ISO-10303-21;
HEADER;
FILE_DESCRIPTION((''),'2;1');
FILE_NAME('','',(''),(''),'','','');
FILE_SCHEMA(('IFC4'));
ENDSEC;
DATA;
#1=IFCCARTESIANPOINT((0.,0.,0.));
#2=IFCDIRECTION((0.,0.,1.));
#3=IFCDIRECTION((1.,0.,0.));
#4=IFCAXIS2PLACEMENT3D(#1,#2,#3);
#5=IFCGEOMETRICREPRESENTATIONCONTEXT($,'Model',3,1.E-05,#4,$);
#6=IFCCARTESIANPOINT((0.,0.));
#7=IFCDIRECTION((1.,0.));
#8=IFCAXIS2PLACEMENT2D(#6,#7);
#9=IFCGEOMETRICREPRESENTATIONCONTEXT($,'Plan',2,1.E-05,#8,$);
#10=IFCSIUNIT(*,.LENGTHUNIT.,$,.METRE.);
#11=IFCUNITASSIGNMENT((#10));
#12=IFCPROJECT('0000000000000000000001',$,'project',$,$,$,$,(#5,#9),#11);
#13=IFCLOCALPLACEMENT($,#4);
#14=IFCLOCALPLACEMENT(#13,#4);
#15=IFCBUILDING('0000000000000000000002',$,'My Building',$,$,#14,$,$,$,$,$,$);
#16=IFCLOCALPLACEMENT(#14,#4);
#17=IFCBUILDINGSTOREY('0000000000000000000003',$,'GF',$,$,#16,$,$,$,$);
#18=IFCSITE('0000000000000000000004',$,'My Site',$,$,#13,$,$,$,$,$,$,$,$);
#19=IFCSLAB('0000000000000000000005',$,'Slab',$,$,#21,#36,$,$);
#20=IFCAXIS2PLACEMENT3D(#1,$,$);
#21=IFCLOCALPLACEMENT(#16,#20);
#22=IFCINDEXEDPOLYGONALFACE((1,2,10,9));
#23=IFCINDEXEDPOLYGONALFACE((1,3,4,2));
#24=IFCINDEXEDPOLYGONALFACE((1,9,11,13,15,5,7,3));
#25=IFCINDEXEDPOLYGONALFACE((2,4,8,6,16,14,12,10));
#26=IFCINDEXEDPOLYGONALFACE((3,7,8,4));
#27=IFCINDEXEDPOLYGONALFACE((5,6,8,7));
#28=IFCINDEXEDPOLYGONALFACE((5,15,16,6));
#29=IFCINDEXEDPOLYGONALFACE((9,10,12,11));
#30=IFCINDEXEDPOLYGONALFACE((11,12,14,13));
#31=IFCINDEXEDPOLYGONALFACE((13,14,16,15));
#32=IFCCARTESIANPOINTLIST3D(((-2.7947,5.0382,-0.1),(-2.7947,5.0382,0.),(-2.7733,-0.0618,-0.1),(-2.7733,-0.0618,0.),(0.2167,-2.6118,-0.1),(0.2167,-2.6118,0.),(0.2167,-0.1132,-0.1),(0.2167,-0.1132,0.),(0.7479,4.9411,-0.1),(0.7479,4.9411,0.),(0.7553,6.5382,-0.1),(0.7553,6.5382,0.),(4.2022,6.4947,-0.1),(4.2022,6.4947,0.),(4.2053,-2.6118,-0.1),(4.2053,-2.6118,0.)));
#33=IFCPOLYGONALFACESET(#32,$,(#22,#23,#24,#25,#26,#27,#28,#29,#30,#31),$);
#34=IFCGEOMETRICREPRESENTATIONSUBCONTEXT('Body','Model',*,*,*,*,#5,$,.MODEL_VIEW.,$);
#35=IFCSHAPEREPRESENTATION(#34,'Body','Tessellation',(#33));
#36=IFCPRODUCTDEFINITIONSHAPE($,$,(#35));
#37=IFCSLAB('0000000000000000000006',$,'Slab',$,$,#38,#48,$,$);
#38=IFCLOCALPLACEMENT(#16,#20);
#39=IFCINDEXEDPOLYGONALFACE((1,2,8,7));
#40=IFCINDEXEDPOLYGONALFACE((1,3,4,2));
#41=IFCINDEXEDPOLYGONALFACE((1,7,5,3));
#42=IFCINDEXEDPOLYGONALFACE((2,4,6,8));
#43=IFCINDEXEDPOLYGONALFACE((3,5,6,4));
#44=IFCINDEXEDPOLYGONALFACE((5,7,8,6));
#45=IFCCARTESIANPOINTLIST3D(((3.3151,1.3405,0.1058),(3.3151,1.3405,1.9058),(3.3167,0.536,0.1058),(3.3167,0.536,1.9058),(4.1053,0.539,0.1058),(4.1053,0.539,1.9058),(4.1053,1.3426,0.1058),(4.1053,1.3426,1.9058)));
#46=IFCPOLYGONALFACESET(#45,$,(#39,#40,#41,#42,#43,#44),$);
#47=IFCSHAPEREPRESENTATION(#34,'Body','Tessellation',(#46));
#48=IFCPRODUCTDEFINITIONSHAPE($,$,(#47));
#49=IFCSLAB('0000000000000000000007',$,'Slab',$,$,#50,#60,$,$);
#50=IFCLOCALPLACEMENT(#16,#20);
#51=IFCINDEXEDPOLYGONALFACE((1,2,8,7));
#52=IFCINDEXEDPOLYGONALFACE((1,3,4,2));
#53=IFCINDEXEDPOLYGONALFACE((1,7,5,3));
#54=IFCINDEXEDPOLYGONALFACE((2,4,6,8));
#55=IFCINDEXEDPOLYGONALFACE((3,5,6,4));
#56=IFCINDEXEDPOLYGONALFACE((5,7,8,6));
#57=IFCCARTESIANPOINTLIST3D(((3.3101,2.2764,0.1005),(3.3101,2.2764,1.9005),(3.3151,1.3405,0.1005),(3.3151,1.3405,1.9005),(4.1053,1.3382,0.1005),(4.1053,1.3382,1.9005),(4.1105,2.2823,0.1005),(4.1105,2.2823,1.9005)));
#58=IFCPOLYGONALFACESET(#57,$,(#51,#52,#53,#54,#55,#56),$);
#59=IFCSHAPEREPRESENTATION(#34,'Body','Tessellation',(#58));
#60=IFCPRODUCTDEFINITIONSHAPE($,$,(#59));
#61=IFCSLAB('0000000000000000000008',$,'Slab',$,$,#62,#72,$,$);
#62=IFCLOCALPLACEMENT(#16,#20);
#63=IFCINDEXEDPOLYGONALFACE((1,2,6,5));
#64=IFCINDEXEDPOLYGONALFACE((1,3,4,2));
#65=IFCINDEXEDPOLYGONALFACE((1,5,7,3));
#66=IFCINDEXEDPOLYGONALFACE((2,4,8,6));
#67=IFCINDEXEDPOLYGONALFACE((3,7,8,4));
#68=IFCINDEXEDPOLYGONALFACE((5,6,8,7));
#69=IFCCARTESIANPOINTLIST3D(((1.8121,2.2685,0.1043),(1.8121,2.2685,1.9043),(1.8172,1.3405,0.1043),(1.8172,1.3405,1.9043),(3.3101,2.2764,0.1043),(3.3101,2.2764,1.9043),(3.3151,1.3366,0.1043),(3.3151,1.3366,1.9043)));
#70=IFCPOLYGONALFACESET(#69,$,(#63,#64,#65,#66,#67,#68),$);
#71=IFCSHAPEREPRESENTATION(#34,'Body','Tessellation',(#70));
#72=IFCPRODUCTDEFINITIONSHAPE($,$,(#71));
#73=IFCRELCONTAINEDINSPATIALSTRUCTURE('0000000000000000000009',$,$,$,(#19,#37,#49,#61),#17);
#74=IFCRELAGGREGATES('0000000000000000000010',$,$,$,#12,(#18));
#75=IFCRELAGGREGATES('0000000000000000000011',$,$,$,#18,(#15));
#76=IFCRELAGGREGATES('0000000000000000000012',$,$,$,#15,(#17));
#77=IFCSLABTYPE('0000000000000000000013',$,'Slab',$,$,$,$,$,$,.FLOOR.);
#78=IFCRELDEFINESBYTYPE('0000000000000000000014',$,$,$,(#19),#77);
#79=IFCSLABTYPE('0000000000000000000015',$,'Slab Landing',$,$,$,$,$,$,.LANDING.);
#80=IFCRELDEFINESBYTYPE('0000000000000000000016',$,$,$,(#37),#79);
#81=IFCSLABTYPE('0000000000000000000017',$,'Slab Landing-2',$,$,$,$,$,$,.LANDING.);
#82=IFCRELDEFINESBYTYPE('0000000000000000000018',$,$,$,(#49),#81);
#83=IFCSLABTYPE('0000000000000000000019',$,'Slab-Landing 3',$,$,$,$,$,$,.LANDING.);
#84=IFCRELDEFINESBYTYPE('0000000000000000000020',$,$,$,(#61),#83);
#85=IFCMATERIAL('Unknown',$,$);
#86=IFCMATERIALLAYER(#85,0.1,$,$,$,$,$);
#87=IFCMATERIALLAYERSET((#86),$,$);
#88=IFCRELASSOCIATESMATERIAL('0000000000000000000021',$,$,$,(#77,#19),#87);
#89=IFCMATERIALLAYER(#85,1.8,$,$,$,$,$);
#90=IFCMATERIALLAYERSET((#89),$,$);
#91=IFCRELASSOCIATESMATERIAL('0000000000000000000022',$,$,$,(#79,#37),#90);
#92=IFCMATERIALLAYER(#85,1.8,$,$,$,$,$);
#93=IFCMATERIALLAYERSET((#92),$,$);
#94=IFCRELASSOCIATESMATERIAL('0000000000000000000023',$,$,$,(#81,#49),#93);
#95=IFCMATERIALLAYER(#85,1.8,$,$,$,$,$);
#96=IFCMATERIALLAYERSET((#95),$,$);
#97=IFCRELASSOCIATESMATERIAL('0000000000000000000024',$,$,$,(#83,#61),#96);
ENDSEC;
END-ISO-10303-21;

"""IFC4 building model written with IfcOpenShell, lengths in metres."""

from ifc_helpers import new_model, si_unit, frame, origin_with_axes, origin_2d_with_axis, place, context, subcontext, project, spatial, indexed_curve, outline, extrude, material, layer, layer_set, layer_usage, type_object, element, save


model = new_model("IFC4")

# Units and contexts
model_context = context("Model", 3, precision=1e-05, world=origin_with_axes())
plan_context = context("Plan", 2, precision=1e-05, world=origin_2d_with_axis())
body_context_1 = subcontext(model_context, "Body", "Model", "MODEL_VIEW")
ifc_project = project(units=[si_unit("LENGTHUNIT", "METRE")], contexts=[model_context, plan_context])

# Site, building, storey
site_placement = place(None, origin_with_axes())
site = spatial("IfcSite", under=ifc_project, at=site_placement, Name="My Site")
building_placement = place(site_placement, origin_with_axes())
building = spatial("IfcBuilding", under=site, at=building_placement, Name="My Building")
storey_placement = place(building_placement, origin_with_axes())
storey = spatial("IfcBuildingStorey", under=building, at=storey_placement, Name="GF")

# Slabs
ifc_material_1 = material(Name="Unknown")
ifc_layer_1 = layer(ifc_material_1, 0.1)
ifc_layer_set_1 = layer_set([ifc_layer_1])
ifc_layer_usage_1 = layer_usage(ifc_layer_set_1, "AXIS3", "POSITIVE", -0.1)
slab_type_1 = type_object("IfcSlabType", Name="Slab", PredefinedType="FLOOR", material=ifc_layer_set_1)
slab_1_placement = place(storey_placement, frame((4.2022, 6.4947, 0.0), z_axis=(0.0, 0.0, 1.0), x_axis=(1.0, 0.0, 0.0)))
element("IfcSlab", 1, at=slab_1_placement, inside=storey, type_object=slab_type_1, material=ifc_layer_usage_1, Name="Slab", context=body_context_1, shape_type="SweptSolid", body=[
    extrude(outline(indexed_curve([(0.0, 0.0), (-3.4469, 0.0435), (-3.4543, -1.5535), (-6.9969, -1.4565), (-6.9755, -6.5565), (-3.9855, -6.6078), (-3.9855, -9.1065), (0.0031, -9.1065), (0.0, 0.0)])), frame((0.0, 0.0, -0.1), z_axis=(0.0, 0.0, 1.0), x_axis=(1.0, 0.0, 0.0)), (0.0, 0.0, 1.0), 0.1),
])
ifc_layer_2 = layer(ifc_material_1, 1.8)
ifc_layer_set_2 = layer_set([ifc_layer_2])
ifc_layer_usage_2 = layer_usage(ifc_layer_set_2, "AXIS3", "POSITIVE", -0.1)
slab_type_2 = type_object("IfcSlabType", Name="Slab Landing", PredefinedType="LANDING", material=ifc_layer_set_2)
slab_2_placement = place(storey_placement, frame((3.3167, 0.536, 0.2058), z_axis=(0.0, 0.0, 1.0), x_axis=(1.0, 0.0, 0.0)))
element("IfcSlab", 2, at=slab_2_placement, inside=storey, type_object=slab_type_2, material=ifc_layer_usage_2, Name="Slab", context=body_context_1, shape_type="SweptSolid", body=[
    extrude(outline(indexed_curve([(-0.0016, 0.8044), (0.7886, 0.8066), (0.7886, 0.003), (0.0, 0.0), (-0.0016, 0.8044)])), frame((0.0, 0.0, -0.1), z_axis=(0.0, 0.0, 1.0), x_axis=(1.0, 0.0, 0.0)), (0.0, 0.0, 1.0), 1.8),
])
ifc_layer_3 = layer(ifc_material_1, 1.8)
ifc_layer_set_3 = layer_set([ifc_layer_3])
ifc_layer_usage_3 = layer_usage(ifc_layer_set_3, "AXIS3", "POSITIVE", -1.8)
slab_type_3 = type_object("IfcSlabType", Name="Slab Landing-2", PredefinedType="LANDING", material=ifc_layer_set_3)
slab_3_placement = place(storey_placement, frame((3.3151, 1.3405, 1.9005), z_axis=(0.0, 0.0, 1.0), x_axis=(1.0, 0.0, 0.0)))
element("IfcSlab", 3, at=slab_3_placement, inside=storey, type_object=slab_type_3, material=ifc_layer_usage_3, Name="Slab", context=body_context_1, shape_type="SweptSolid", body=[
    extrude(outline(indexed_curve([(0.0, 0.0), (-0.005, 0.936), (0.7954, 0.9418), (0.7902, -0.0023), (0.0, 0.0)])), frame((0.0, 0.0, -1.8), z_axis=(0.0, 0.0, 1.0), x_axis=(1.0, 0.0, 0.0)), (0.0, 0.0, 1.0), 1.8),
])
ifc_layer_4 = layer(ifc_material_1, 1.8)
ifc_layer_set_4 = layer_set([ifc_layer_4])
ifc_layer_usage_4 = layer_usage(ifc_layer_set_4, "AXIS3", "POSITIVE", -1.8)
slab_type_4 = type_object("IfcSlabType", Name="Slab-Landing 3", PredefinedType="LANDING", material=ifc_layer_set_4)
slab_4_placement = place(storey_placement, frame((1.8172, 1.3405, 1.9043), z_axis=(0.0, 0.0, 1.0), x_axis=(1.0, 0.0, 0.0)))
element("IfcSlab", 4, at=slab_4_placement, inside=storey, type_object=slab_type_4, material=ifc_layer_usage_4, Name="Slab", context=body_context_1, shape_type="SweptSolid", body=[
    extrude(outline(indexed_curve([(0.0, 0.0), (1.4979, -0.0039), (1.4929, 0.936), (-0.0051, 0.928), (0.0, 0.0)])), frame((0.0, 0.0, -1.8), z_axis=(0.0, 0.0, 1.0), x_axis=(1.0, 0.0, 0.0)), (0.0, 0.0, 1.0), 1.8),
])

save(model, "model.ifc")
